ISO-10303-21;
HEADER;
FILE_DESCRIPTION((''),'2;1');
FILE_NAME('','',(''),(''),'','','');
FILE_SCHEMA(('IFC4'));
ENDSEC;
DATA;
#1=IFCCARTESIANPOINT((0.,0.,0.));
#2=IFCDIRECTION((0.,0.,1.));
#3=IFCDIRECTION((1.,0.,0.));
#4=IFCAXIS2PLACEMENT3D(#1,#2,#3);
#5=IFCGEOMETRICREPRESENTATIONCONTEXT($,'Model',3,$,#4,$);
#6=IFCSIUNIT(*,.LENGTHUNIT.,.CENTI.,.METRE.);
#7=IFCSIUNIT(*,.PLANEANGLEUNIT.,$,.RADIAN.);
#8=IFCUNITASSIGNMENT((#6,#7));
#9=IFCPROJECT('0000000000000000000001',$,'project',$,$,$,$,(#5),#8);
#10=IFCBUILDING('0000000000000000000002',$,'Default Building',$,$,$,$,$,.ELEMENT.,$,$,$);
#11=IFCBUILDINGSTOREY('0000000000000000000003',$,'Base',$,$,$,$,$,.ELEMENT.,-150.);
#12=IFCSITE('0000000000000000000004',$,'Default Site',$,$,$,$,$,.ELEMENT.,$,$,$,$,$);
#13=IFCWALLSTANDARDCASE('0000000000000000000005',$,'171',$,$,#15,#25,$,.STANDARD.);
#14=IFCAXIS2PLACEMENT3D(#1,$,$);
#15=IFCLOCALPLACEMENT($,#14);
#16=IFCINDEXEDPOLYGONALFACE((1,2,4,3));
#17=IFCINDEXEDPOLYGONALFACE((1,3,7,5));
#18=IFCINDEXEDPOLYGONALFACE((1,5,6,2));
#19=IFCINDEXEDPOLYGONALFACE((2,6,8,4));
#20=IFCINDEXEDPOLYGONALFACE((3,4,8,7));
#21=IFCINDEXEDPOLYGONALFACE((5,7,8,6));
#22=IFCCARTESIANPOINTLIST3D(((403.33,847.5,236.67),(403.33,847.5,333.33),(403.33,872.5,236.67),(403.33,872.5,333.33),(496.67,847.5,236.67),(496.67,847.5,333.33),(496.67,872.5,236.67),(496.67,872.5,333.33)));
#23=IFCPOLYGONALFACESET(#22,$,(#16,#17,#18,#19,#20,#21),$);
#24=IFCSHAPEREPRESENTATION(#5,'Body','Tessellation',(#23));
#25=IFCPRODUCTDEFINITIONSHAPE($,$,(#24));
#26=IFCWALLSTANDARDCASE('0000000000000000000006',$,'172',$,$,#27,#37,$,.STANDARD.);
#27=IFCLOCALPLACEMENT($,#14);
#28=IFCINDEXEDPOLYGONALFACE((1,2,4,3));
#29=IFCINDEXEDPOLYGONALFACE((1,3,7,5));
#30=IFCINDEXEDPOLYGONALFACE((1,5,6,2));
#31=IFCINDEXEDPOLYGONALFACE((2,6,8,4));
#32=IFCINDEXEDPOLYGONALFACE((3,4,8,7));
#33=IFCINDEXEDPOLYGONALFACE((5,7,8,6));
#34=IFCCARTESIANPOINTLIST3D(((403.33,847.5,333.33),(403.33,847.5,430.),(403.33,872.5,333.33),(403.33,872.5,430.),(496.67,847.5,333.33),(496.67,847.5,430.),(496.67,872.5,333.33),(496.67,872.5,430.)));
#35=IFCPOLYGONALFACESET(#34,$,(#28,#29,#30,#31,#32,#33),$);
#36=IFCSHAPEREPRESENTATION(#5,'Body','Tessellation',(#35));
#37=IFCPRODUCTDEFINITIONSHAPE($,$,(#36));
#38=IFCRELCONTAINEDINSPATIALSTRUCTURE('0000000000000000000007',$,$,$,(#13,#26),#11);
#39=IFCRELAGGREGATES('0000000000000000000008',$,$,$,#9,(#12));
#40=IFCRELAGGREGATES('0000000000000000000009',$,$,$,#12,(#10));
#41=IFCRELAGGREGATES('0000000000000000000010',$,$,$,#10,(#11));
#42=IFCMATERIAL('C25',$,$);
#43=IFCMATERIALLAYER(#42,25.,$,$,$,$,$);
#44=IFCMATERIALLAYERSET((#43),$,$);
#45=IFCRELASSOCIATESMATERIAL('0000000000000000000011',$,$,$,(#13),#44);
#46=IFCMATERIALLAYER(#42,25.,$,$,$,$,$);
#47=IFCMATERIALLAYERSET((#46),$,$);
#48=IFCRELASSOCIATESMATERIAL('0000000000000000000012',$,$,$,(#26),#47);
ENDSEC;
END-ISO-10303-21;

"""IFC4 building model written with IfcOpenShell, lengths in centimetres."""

from ifc_helpers import new_model, si_unit, frame, origin_with_axes, origin_2d_with_axis, place, context, project, spatial, rectangle, extrude, material, layer, layer_set, layer_usage, element, save


model = new_model("IFC4")

# Units and contexts
model_context = context("Model", 3, world=origin_with_axes())
ifc_project = project(units=[si_unit("LENGTHUNIT", "METRE", prefix="CENTI"), si_unit("PLANEANGLEUNIT", "RADIAN")], contexts=[model_context])

# Site, building, storey
site = spatial("IfcSite", under=ifc_project, Name="Default Site", CompositionType="ELEMENT")
building = spatial("IfcBuilding", under=site, Name="Default Building", CompositionType="ELEMENT")
storey = spatial("IfcBuildingStorey", under=building, Name="Base", CompositionType="ELEMENT", Elevation=-150.0)

# Walls
ifc_material = material(Name="C25")
ifc_layer_1 = layer(ifc_material, 25.0)
ifc_layer_set_1 = layer_set([ifc_layer_1])
ifc_layer_usage_1 = layer_usage(ifc_layer_set_1, "AXIS2", "POSITIVE", -25.0)
wall_1_placement = place(None, frame((450.0, 860.0, 236.67), z_axis=(0.0, 0.0, 1.0), x_axis=(1.0, 0.0, 0.0)))
element("IfcWallStandardCase", 1, at=wall_1_placement, inside=storey, material=ifc_layer_usage_1, Name="171", PredefinedType="STANDARD", context=model_context, shape_type="SweptSolid", body=[
    extrude(rectangle(XDim=93.33, YDim=25.0, at=origin_2d_with_axis()), origin_with_axes(), (0.0, 0.0, 1.0), 96.67),
])
ifc_layer_2 = layer(ifc_material, 25.0)
ifc_layer_set_2 = layer_set([ifc_layer_2])
ifc_layer_usage_2 = layer_usage(ifc_layer_set_2, "AXIS2", "POSITIVE", -25.0)
wall_2_placement = place(None, frame((450.0, 860.0, 333.33), z_axis=(0.0, 0.0, 1.0), x_axis=(1.0, 0.0, 0.0)))
element("IfcWallStandardCase", 2, at=wall_2_placement, inside=storey, material=ifc_layer_usage_2, Name="172", PredefinedType="STANDARD", context=model_context, shape_type="SweptSolid", body=[
    extrude(rectangle(XDim=93.33, YDim=25.0, at=origin_2d_with_axis()), origin_with_axes(), (0.0, 0.0, 1.0), 96.67),
])

save(model, "model.ifc")
